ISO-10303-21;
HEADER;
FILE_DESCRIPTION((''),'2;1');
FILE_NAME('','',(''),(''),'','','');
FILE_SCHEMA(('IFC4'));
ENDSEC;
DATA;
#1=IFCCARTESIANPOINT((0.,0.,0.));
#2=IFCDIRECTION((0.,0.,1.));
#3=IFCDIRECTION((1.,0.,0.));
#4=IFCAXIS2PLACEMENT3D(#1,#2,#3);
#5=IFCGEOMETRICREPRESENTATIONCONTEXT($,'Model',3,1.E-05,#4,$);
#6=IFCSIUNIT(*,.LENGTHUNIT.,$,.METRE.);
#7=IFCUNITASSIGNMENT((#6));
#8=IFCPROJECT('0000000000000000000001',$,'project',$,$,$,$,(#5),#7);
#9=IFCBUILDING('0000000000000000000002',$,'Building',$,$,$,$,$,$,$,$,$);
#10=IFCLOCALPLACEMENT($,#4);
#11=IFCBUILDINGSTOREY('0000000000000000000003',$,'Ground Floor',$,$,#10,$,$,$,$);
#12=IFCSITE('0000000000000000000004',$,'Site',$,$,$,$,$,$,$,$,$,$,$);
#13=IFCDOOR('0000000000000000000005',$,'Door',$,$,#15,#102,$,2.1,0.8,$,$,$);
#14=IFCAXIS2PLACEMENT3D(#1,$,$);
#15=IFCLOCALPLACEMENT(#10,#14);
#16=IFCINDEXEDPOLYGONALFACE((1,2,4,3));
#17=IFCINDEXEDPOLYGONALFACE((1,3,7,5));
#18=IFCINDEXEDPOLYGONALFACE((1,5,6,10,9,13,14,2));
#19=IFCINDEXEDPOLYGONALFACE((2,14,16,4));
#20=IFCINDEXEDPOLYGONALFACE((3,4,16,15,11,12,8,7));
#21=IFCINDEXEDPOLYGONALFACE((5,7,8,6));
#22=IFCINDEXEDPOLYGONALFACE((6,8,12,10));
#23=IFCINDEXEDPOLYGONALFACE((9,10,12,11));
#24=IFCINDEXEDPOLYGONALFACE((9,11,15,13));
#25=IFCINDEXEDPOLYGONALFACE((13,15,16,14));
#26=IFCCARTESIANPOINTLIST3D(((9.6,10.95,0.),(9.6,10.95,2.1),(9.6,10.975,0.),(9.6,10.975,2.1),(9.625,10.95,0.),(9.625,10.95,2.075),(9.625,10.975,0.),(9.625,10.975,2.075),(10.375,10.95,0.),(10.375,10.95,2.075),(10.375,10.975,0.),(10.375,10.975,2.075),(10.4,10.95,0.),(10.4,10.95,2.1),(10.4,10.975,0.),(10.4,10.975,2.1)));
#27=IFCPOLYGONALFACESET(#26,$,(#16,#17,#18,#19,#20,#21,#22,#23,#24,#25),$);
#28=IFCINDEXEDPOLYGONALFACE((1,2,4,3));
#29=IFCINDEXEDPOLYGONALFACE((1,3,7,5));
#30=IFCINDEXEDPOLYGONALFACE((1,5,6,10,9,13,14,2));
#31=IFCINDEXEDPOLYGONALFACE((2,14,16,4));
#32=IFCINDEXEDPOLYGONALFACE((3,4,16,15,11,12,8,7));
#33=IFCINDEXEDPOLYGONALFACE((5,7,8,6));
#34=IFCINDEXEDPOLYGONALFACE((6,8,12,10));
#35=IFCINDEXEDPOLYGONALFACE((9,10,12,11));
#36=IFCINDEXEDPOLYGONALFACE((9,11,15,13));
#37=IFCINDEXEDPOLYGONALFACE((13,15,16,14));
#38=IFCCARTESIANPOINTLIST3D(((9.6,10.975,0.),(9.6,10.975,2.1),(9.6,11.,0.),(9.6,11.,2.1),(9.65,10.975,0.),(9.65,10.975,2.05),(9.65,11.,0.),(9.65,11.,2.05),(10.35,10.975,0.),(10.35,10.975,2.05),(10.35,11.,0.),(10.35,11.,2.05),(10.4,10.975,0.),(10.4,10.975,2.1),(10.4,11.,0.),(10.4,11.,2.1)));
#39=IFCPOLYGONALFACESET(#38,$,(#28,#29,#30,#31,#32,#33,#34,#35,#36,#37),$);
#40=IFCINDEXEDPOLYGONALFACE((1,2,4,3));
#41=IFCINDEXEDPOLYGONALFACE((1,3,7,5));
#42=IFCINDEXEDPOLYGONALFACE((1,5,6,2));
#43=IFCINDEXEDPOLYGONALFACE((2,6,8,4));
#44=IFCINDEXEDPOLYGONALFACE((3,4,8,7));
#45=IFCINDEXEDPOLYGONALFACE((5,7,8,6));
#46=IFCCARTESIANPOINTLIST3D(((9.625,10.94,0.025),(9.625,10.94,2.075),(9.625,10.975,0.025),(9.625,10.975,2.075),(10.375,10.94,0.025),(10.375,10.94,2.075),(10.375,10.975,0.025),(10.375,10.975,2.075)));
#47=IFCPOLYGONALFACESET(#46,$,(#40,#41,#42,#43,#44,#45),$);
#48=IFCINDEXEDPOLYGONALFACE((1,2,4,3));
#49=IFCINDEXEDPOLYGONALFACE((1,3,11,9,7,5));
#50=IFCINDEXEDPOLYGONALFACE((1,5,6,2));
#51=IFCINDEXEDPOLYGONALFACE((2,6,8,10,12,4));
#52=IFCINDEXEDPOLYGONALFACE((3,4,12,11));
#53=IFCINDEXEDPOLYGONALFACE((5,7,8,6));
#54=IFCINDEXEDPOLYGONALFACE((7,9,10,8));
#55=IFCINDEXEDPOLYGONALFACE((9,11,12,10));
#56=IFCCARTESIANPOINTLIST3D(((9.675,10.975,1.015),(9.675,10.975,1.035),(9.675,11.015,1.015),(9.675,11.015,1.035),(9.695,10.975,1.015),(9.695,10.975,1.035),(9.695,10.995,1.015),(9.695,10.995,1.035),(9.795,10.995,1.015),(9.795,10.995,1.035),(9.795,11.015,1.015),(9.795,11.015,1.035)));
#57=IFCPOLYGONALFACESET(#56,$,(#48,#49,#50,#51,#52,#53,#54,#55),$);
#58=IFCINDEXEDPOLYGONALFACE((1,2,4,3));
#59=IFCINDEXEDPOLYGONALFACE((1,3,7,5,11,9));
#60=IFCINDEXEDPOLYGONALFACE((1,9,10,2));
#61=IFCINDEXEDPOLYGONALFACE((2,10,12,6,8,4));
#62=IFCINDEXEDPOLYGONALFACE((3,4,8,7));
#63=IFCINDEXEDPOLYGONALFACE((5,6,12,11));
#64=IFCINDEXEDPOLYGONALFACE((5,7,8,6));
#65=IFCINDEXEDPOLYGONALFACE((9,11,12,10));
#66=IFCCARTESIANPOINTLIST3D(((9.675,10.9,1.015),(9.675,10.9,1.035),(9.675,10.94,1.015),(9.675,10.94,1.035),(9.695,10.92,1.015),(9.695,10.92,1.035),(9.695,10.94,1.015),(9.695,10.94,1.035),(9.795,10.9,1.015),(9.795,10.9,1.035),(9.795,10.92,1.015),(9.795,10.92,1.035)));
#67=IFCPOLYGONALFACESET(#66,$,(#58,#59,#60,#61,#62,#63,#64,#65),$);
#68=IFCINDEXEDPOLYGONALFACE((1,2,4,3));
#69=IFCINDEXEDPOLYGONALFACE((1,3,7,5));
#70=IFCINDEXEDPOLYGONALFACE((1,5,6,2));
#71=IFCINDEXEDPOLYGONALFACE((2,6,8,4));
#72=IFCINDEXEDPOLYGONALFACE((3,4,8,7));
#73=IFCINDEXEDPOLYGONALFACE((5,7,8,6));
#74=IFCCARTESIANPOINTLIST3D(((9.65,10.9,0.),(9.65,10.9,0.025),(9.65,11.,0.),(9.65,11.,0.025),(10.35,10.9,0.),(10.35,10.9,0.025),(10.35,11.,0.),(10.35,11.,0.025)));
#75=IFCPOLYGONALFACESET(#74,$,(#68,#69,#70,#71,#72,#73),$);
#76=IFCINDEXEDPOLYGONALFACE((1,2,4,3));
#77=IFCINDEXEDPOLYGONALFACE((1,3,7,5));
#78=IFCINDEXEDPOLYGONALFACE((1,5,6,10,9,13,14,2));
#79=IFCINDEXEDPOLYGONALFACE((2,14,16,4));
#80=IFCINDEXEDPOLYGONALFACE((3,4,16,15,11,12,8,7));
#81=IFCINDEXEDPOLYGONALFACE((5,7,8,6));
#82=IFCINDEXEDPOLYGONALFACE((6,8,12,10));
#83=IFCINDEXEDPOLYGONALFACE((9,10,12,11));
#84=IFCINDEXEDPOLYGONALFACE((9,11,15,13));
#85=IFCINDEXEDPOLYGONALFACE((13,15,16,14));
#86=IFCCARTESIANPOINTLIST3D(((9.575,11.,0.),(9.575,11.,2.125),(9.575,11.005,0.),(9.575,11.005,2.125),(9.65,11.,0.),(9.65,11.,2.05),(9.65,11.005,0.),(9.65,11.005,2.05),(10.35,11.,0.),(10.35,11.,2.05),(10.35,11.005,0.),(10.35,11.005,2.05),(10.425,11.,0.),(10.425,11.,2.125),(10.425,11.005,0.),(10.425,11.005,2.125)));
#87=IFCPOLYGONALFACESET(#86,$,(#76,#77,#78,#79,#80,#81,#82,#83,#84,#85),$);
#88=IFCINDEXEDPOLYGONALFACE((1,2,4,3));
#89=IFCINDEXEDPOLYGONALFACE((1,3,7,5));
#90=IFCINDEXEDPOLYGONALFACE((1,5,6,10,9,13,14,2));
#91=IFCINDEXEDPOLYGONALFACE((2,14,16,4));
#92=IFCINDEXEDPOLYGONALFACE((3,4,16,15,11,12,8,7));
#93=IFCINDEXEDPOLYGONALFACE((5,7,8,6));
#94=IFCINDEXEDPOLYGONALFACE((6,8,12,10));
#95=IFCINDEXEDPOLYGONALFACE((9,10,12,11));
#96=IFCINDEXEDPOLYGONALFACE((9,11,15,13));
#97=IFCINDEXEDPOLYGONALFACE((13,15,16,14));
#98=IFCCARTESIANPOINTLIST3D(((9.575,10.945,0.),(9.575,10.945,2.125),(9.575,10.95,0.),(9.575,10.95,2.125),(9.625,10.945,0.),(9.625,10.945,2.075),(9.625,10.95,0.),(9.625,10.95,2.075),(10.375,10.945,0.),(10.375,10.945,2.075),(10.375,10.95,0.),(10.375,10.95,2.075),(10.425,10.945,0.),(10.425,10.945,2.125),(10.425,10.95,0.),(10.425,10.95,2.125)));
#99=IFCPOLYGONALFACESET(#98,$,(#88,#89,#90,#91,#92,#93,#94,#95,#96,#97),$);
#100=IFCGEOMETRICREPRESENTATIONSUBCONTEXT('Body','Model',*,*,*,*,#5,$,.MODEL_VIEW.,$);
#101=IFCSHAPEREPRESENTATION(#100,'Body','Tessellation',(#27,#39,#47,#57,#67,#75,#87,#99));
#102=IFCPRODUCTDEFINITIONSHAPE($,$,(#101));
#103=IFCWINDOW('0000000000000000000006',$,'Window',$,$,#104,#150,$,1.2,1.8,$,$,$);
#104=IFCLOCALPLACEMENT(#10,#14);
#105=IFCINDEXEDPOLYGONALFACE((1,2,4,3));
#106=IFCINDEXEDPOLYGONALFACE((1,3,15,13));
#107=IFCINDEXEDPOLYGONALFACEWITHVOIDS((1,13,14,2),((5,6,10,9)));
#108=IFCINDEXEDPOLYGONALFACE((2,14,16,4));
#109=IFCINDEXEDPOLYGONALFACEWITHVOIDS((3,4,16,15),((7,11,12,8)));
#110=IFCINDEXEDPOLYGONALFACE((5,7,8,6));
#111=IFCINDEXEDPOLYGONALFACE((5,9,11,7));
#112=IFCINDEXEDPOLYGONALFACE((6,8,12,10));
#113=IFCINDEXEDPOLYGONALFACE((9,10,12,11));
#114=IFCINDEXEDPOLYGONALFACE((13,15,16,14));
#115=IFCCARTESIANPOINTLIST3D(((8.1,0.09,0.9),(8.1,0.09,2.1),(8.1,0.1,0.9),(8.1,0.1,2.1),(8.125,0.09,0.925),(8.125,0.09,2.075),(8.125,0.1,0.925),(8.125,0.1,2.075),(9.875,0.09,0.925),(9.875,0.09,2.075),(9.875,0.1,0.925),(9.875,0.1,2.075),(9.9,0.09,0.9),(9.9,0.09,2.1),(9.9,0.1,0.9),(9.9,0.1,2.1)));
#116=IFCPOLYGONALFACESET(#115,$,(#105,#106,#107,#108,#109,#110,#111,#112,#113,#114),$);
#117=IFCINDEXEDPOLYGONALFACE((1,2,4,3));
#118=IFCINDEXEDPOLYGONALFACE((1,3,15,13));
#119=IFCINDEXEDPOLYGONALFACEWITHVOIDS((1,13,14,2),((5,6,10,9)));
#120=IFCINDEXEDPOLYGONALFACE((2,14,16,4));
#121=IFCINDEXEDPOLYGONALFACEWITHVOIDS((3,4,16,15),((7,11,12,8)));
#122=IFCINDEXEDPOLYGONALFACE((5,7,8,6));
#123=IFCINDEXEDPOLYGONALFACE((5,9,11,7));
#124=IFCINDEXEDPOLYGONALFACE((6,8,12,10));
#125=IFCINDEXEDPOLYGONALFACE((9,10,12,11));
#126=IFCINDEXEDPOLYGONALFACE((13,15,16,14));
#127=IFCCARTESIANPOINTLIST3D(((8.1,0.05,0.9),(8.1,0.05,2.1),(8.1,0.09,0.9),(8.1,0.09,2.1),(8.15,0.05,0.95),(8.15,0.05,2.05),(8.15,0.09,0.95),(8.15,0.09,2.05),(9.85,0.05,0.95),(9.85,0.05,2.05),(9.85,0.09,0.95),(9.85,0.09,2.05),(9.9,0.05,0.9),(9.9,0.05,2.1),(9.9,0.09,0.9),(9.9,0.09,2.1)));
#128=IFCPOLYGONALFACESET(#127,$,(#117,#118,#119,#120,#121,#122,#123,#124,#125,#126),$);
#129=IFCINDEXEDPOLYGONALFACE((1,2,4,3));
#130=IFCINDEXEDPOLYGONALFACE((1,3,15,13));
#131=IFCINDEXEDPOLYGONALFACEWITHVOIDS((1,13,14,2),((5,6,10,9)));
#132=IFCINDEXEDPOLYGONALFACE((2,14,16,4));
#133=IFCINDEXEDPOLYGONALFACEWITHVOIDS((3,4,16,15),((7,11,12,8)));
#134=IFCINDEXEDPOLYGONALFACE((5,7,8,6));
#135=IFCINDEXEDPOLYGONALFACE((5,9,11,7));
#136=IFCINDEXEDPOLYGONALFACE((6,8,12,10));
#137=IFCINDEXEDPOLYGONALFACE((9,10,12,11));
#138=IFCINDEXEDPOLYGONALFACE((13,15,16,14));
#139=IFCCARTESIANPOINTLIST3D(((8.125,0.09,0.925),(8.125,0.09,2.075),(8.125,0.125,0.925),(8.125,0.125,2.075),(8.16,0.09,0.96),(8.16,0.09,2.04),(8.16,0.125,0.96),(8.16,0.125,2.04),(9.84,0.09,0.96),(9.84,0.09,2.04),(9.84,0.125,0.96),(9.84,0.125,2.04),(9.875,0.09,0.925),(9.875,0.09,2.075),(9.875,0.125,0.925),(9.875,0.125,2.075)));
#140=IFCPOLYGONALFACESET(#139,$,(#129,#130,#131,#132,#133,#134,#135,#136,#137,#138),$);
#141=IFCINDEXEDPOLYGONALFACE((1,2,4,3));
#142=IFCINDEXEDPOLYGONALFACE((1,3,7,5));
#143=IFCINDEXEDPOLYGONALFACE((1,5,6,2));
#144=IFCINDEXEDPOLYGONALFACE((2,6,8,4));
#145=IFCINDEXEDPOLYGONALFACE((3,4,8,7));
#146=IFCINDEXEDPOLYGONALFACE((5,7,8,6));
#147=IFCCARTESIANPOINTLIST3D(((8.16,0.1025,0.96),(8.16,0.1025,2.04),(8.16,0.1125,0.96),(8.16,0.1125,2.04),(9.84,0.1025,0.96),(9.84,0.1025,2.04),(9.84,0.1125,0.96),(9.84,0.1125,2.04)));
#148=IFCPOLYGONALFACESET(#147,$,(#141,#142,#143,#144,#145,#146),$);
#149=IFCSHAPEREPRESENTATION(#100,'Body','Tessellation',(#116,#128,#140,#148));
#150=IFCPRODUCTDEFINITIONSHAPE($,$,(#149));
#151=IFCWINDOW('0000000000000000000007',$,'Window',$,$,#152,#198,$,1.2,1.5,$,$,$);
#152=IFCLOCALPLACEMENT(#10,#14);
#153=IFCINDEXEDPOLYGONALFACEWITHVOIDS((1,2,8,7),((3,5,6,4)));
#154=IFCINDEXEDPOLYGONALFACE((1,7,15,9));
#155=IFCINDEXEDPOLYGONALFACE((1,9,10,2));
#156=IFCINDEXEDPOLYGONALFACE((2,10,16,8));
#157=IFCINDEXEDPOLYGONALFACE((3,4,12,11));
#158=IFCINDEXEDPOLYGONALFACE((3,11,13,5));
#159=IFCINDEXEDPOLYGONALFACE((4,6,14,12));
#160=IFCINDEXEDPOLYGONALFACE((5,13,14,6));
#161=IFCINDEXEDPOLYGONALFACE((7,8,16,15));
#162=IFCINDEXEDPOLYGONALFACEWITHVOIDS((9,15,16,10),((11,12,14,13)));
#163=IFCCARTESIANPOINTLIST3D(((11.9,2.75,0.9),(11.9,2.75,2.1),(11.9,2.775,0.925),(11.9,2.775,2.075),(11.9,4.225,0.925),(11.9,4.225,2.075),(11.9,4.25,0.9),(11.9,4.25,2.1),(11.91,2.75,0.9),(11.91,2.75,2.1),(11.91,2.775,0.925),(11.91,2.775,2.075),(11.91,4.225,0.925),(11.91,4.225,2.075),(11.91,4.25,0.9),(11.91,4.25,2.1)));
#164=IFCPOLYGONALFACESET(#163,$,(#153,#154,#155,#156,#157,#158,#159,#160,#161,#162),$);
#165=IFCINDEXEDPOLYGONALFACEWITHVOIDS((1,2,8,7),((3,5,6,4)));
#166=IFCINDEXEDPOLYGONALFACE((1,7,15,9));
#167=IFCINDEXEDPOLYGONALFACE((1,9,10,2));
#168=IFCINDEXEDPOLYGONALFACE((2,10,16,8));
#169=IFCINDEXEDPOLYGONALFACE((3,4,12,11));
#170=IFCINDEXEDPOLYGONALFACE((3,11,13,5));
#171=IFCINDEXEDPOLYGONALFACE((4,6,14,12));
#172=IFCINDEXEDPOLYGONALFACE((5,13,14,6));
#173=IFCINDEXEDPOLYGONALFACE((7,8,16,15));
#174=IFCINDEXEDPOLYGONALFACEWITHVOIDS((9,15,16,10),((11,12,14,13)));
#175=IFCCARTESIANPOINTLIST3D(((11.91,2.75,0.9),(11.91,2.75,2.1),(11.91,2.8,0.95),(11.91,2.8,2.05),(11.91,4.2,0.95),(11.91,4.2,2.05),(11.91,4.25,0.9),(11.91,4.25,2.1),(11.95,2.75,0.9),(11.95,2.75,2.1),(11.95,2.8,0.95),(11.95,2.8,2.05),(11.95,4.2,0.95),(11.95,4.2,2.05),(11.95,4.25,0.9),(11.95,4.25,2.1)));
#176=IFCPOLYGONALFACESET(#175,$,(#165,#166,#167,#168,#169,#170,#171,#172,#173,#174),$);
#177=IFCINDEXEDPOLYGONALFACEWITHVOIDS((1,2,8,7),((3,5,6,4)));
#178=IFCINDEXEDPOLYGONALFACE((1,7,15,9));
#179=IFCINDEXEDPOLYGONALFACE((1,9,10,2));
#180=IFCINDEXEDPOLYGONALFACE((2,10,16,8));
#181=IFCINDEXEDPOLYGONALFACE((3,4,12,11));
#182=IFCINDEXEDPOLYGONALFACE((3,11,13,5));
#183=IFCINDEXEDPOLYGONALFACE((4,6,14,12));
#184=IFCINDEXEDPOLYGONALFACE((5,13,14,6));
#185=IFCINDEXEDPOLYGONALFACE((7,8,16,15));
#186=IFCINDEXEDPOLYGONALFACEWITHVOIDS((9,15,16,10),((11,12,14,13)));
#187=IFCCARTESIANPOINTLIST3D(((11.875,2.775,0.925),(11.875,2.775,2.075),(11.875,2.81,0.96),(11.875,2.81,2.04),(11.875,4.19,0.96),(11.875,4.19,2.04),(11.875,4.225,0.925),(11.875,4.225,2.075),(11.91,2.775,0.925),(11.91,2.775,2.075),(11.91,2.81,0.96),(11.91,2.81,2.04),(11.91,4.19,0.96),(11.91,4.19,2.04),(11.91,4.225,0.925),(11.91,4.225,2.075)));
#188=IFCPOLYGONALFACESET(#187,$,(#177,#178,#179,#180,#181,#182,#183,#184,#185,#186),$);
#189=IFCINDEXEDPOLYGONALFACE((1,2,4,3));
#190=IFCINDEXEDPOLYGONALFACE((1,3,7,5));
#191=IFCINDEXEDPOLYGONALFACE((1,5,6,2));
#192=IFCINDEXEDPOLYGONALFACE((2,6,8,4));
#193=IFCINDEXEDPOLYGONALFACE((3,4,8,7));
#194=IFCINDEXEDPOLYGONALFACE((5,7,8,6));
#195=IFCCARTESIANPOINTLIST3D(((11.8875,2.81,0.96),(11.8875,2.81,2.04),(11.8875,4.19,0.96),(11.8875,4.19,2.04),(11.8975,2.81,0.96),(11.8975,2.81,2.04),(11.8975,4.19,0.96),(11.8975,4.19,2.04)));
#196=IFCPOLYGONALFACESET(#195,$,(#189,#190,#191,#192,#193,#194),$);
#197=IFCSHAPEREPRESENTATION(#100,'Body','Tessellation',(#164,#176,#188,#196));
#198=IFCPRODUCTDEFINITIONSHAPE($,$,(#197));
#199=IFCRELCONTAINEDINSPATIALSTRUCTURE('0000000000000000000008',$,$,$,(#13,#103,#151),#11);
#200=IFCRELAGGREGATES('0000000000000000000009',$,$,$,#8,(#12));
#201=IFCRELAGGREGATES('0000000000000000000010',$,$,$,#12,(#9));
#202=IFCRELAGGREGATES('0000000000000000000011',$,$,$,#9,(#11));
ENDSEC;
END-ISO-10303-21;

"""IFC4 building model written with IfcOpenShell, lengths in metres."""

from ifc_helpers import new_model, si_unit, frame, origin_with_axes, place, context, subcontext, project, spatial, line, indexed_curve, outline, extrude, element, save


model = new_model("IFC4")

# Units and contexts
model_context = context("Model", 3, precision=1e-05, world=origin_with_axes())
body_context = subcontext(model_context, "Body", "Model", "MODEL_VIEW")
ifc_project = project(units=[si_unit("LENGTHUNIT", "METRE")], contexts=[model_context])

# Site, building, storey
site = spatial("IfcSite", under=ifc_project, Name="Site")
building = spatial("IfcBuilding", under=site, Name="Building")
storey_placement = place(None, origin_with_axes())
storey = spatial("IfcBuildingStorey", under=building, at=storey_placement, Name="Ground Floor")

# Door
door_1_placement = place(storey_placement, frame((10.4, 11.0, 0.0), z_axis=(0.0, 0.0, 1.0), x_axis=(-1.0, 0.0, 0.0)))
element("IfcDoor", 1, at=door_1_placement, inside=storey, Name="Door", OverallHeight=2.1, OverallWidth=0.8, context=body_context, shape_type="SweptSolid", body=[
    extrude(outline(indexed_curve([(0.0, 0.0), (0.0, 2.1), (0.8, 2.1), (0.8, 0.0), (0.775, 0.0), (0.775, 2.075), (0.025, 2.075), (0.025, 0.0)], segments=[line(1, 2, 3, 4, 5, 6, 7, 8, 1)])), frame((0.0, 0.025, 0.0), z_axis=(0.0, -1.0, 0.0), x_axis=(1.0, 0.0, 0.0)), (0.0, 0.0, -1.0), 0.025),
    extrude(outline(indexed_curve([(0.0, 0.0), (0.0, 2.1), (0.8, 2.1), (0.8, 0.0), (0.75, 0.0), (0.75, 2.05), (0.05, 2.05), (0.05, 0.0)], segments=[line(1, 2, 3, 4, 5, 6, 7, 8, 1)])), frame((0.0, 0.0, 0.0), z_axis=(0.0, -1.0, 0.0), x_axis=(1.0, 0.0, 0.0)), (0.0, 0.0, -1.0), 0.025),
    extrude(outline(indexed_curve([(0.0, 0.0), (0.75, 0.0), (0.75, 0.035), (0.0, 0.035)], segments=[line(1, 2, 3, 4, 1)])), frame((0.025, 0.025, 0.025), z_axis=(0.0, 0.0, 1.0), x_axis=(1.0, 0.0, 0.0)), (0.0, 0.0, 1.0), 2.05),
    extrude(outline(indexed_curve([(0.0, 0.0), (0.0, -0.04), (-0.12, -0.04), (-0.12, -0.02), (-0.02, -0.02), (-0.02, 0.0)], segments=[line(1, 2, 3, 4, 5, 6, 1)])), frame((0.725, 0.025, 1.015), z_axis=(0.0, 0.0, 1.0), x_axis=(1.0, 0.0, 0.0)), (0.0, 0.0, 1.0), 0.02),
    extrude(outline(indexed_curve([(0.0, 0.0), (0.0, 0.04), (-0.12, 0.04), (-0.12, 0.02), (-0.02, 0.02), (-0.02, 0.0)], segments=[line(1, 2, 3, 4, 5, 6, 1)])), frame((0.725, 0.06, 1.015), z_axis=(0.0, 0.0, 1.0), x_axis=(1.0, 0.0, 0.0)), (0.0, 0.0, 1.0), 0.02),
    extrude(outline(indexed_curve([(0.0, 0.0), (0.7, 0.0), (0.7, 0.1), (0.0, 0.1)], segments=[line(1, 2, 3, 4, 1)])), frame((0.05, 0.0, 0.0), z_axis=(0.0, 0.0, 1.0), x_axis=(1.0, 0.0, 0.0)), (0.0, 0.0, 1.0), 0.025),
    extrude(outline(indexed_curve([(0.0, 0.0), (0.0, 2.125), (0.85, 2.125), (0.85, 0.0), (0.775, 0.0), (0.775, 2.05), (0.075, 2.05), (0.075, 0.0)], segments=[line(1, 2, 3, 4, 5, 6, 7, 8, 1)])), frame((-0.025, -0.005, 0.0), z_axis=(0.0, -1.0, 0.0), x_axis=(1.0, 0.0, 0.0)), (0.0, 0.0, -1.0), 0.005),
    extrude(outline(indexed_curve([(0.0, 0.0), (0.0, 2.125), (0.85, 2.125), (0.85, 0.0), (0.8, 0.0), (0.8, 2.075), (0.05, 2.075), (0.05, 0.0)], segments=[line(1, 2, 3, 4, 5, 6, 7, 8, 1)])), frame((-0.025, 0.05, 0.0), z_axis=(0.0, -1.0, 0.0), x_axis=(1.0, 0.0, 0.0)), (0.0, 0.0, -1.0), 0.005),
])

# Windows
window_1_placement = place(storey_placement, frame((8.1, 0.0, 0.9), z_axis=(0.0, 0.0, 1.0), x_axis=(1.0, 0.0, 0.0)))
element("IfcWindow", 2, at=window_1_placement, inside=storey, Name="Window", OverallHeight=1.2, OverallWidth=1.8, context=body_context, shape_type="SweptSolid", body=[
    extrude(outline(indexed_curve([(0.0, 0.0), (1.8, 0.0), (1.8, 1.2), (0.0, 1.2)], segments=[line(1, 2, 3, 4, 1)]), holes=[indexed_curve([(0.025, 0.025), (1.775, 0.025), (1.775, 1.175), (0.025, 1.175)], segments=[line(1, 2, 3, 4, 1)])]), frame((0.0, 0.09, 0.0), z_axis=(0.0, -1.0, 0.0), x_axis=(1.0, 0.0, 0.0)), (0.0, 0.0, -1.0), 0.01),
    extrude(outline(indexed_curve([(0.0, 0.0), (1.8, 0.0), (1.8, 1.2), (0.0, 1.2)], segments=[line(1, 2, 3, 4, 1)]), holes=[indexed_curve([(0.05, 0.05), (1.75, 0.05), (1.75, 1.15), (0.05, 1.15)], segments=[line(1, 2, 3, 4, 1)])]), frame((0.0, 0.05, 0.0), z_axis=(0.0, -1.0, 0.0), x_axis=(1.0, 0.0, 0.0)), (0.0, 0.0, -1.0), 0.04),
    extrude(outline(indexed_curve([(0.0, 0.0), (1.75, 0.0), (1.75, 1.15), (0.0, 1.15)], segments=[line(1, 2, 3, 4, 1)]), holes=[indexed_curve([(0.035, 0.035), (1.715, 0.035), (1.715, 1.115), (0.035, 1.115)], segments=[line(1, 2, 3, 4, 1)])]), frame((0.025, 0.09, 0.025), z_axis=(0.0, -1.0, 0.0), x_axis=(1.0, 0.0, 0.0)), (0.0, 0.0, -1.0), 0.035),
    extrude(outline(indexed_curve([(0.035, 0.035), (1.715, 0.035), (1.715, 1.115), (0.035, 1.115)], segments=[line(1, 2, 3, 4, 1)])), frame((0.025, 0.1025, 0.025), z_axis=(0.0, -1.0, 0.0), x_axis=(1.0, 0.0, 0.0)), (0.0, 0.0, -1.0), 0.01),
])
for number, where, z_axis, x_axis, name in (
    (3, (12.0, 2.75, 0.9), (0.0, 0.0, 1.0), (0.0, 1.0, 0.0), "Window"),
):
    element("IfcWindow", number, at=place(storey_placement, frame(where, z_axis=z_axis, x_axis=x_axis)), inside=storey, Name=name, OverallHeight=1.2, OverallWidth=1.5, context=body_context, shape_type="SweptSolid", body=[
        extrude(outline(indexed_curve([(0.0, 0.0), (1.5, 0.0), (1.5, 1.2), (0.0, 1.2)], segments=[line(1, 2, 3, 4, 1)]), holes=[indexed_curve([(0.025, 0.025), (1.475, 0.025), (1.475, 1.175), (0.025, 1.175)], segments=[line(1, 2, 3, 4, 1)])]), frame((0.0, 0.09, 0.0), z_axis=(0.0, -1.0, 0.0), x_axis=(1.0, 0.0, 0.0)), (0.0, 0.0, -1.0), 0.01),
        extrude(outline(indexed_curve([(0.0, 0.0), (1.5, 0.0), (1.5, 1.2), (0.0, 1.2)], segments=[line(1, 2, 3, 4, 1)]), holes=[indexed_curve([(0.05, 0.05), (1.45, 0.05), (1.45, 1.15), (0.05, 1.15)], segments=[line(1, 2, 3, 4, 1)])]), frame((0.0, 0.05, 0.0), z_axis=(0.0, -1.0, 0.0), x_axis=(1.0, 0.0, 0.0)), (0.0, 0.0, -1.0), 0.04),
        extrude(outline(indexed_curve([(0.0, 0.0), (1.45, 0.0), (1.45, 1.15), (0.0, 1.15)], segments=[line(1, 2, 3, 4, 1)]), holes=[indexed_curve([(0.035, 0.035), (1.415, 0.035), (1.415, 1.115), (0.035, 1.115)], segments=[line(1, 2, 3, 4, 1)])]), frame((0.025, 0.09, 0.025), z_axis=(0.0, -1.0, 0.0), x_axis=(1.0, 0.0, 0.0)), (0.0, 0.0, -1.0), 0.035),
        extrude(outline(indexed_curve([(0.035, 0.035), (1.415, 0.035), (1.415, 1.115), (0.035, 1.115)], segments=[line(1, 2, 3, 4, 1)])), frame((0.025, 0.1025, 0.025), z_axis=(0.0, -1.0, 0.0), x_axis=(1.0, 0.0, 0.0)), (0.0, 0.0, -1.0), 0.01),
    ])

save(model, "model.ifc")
